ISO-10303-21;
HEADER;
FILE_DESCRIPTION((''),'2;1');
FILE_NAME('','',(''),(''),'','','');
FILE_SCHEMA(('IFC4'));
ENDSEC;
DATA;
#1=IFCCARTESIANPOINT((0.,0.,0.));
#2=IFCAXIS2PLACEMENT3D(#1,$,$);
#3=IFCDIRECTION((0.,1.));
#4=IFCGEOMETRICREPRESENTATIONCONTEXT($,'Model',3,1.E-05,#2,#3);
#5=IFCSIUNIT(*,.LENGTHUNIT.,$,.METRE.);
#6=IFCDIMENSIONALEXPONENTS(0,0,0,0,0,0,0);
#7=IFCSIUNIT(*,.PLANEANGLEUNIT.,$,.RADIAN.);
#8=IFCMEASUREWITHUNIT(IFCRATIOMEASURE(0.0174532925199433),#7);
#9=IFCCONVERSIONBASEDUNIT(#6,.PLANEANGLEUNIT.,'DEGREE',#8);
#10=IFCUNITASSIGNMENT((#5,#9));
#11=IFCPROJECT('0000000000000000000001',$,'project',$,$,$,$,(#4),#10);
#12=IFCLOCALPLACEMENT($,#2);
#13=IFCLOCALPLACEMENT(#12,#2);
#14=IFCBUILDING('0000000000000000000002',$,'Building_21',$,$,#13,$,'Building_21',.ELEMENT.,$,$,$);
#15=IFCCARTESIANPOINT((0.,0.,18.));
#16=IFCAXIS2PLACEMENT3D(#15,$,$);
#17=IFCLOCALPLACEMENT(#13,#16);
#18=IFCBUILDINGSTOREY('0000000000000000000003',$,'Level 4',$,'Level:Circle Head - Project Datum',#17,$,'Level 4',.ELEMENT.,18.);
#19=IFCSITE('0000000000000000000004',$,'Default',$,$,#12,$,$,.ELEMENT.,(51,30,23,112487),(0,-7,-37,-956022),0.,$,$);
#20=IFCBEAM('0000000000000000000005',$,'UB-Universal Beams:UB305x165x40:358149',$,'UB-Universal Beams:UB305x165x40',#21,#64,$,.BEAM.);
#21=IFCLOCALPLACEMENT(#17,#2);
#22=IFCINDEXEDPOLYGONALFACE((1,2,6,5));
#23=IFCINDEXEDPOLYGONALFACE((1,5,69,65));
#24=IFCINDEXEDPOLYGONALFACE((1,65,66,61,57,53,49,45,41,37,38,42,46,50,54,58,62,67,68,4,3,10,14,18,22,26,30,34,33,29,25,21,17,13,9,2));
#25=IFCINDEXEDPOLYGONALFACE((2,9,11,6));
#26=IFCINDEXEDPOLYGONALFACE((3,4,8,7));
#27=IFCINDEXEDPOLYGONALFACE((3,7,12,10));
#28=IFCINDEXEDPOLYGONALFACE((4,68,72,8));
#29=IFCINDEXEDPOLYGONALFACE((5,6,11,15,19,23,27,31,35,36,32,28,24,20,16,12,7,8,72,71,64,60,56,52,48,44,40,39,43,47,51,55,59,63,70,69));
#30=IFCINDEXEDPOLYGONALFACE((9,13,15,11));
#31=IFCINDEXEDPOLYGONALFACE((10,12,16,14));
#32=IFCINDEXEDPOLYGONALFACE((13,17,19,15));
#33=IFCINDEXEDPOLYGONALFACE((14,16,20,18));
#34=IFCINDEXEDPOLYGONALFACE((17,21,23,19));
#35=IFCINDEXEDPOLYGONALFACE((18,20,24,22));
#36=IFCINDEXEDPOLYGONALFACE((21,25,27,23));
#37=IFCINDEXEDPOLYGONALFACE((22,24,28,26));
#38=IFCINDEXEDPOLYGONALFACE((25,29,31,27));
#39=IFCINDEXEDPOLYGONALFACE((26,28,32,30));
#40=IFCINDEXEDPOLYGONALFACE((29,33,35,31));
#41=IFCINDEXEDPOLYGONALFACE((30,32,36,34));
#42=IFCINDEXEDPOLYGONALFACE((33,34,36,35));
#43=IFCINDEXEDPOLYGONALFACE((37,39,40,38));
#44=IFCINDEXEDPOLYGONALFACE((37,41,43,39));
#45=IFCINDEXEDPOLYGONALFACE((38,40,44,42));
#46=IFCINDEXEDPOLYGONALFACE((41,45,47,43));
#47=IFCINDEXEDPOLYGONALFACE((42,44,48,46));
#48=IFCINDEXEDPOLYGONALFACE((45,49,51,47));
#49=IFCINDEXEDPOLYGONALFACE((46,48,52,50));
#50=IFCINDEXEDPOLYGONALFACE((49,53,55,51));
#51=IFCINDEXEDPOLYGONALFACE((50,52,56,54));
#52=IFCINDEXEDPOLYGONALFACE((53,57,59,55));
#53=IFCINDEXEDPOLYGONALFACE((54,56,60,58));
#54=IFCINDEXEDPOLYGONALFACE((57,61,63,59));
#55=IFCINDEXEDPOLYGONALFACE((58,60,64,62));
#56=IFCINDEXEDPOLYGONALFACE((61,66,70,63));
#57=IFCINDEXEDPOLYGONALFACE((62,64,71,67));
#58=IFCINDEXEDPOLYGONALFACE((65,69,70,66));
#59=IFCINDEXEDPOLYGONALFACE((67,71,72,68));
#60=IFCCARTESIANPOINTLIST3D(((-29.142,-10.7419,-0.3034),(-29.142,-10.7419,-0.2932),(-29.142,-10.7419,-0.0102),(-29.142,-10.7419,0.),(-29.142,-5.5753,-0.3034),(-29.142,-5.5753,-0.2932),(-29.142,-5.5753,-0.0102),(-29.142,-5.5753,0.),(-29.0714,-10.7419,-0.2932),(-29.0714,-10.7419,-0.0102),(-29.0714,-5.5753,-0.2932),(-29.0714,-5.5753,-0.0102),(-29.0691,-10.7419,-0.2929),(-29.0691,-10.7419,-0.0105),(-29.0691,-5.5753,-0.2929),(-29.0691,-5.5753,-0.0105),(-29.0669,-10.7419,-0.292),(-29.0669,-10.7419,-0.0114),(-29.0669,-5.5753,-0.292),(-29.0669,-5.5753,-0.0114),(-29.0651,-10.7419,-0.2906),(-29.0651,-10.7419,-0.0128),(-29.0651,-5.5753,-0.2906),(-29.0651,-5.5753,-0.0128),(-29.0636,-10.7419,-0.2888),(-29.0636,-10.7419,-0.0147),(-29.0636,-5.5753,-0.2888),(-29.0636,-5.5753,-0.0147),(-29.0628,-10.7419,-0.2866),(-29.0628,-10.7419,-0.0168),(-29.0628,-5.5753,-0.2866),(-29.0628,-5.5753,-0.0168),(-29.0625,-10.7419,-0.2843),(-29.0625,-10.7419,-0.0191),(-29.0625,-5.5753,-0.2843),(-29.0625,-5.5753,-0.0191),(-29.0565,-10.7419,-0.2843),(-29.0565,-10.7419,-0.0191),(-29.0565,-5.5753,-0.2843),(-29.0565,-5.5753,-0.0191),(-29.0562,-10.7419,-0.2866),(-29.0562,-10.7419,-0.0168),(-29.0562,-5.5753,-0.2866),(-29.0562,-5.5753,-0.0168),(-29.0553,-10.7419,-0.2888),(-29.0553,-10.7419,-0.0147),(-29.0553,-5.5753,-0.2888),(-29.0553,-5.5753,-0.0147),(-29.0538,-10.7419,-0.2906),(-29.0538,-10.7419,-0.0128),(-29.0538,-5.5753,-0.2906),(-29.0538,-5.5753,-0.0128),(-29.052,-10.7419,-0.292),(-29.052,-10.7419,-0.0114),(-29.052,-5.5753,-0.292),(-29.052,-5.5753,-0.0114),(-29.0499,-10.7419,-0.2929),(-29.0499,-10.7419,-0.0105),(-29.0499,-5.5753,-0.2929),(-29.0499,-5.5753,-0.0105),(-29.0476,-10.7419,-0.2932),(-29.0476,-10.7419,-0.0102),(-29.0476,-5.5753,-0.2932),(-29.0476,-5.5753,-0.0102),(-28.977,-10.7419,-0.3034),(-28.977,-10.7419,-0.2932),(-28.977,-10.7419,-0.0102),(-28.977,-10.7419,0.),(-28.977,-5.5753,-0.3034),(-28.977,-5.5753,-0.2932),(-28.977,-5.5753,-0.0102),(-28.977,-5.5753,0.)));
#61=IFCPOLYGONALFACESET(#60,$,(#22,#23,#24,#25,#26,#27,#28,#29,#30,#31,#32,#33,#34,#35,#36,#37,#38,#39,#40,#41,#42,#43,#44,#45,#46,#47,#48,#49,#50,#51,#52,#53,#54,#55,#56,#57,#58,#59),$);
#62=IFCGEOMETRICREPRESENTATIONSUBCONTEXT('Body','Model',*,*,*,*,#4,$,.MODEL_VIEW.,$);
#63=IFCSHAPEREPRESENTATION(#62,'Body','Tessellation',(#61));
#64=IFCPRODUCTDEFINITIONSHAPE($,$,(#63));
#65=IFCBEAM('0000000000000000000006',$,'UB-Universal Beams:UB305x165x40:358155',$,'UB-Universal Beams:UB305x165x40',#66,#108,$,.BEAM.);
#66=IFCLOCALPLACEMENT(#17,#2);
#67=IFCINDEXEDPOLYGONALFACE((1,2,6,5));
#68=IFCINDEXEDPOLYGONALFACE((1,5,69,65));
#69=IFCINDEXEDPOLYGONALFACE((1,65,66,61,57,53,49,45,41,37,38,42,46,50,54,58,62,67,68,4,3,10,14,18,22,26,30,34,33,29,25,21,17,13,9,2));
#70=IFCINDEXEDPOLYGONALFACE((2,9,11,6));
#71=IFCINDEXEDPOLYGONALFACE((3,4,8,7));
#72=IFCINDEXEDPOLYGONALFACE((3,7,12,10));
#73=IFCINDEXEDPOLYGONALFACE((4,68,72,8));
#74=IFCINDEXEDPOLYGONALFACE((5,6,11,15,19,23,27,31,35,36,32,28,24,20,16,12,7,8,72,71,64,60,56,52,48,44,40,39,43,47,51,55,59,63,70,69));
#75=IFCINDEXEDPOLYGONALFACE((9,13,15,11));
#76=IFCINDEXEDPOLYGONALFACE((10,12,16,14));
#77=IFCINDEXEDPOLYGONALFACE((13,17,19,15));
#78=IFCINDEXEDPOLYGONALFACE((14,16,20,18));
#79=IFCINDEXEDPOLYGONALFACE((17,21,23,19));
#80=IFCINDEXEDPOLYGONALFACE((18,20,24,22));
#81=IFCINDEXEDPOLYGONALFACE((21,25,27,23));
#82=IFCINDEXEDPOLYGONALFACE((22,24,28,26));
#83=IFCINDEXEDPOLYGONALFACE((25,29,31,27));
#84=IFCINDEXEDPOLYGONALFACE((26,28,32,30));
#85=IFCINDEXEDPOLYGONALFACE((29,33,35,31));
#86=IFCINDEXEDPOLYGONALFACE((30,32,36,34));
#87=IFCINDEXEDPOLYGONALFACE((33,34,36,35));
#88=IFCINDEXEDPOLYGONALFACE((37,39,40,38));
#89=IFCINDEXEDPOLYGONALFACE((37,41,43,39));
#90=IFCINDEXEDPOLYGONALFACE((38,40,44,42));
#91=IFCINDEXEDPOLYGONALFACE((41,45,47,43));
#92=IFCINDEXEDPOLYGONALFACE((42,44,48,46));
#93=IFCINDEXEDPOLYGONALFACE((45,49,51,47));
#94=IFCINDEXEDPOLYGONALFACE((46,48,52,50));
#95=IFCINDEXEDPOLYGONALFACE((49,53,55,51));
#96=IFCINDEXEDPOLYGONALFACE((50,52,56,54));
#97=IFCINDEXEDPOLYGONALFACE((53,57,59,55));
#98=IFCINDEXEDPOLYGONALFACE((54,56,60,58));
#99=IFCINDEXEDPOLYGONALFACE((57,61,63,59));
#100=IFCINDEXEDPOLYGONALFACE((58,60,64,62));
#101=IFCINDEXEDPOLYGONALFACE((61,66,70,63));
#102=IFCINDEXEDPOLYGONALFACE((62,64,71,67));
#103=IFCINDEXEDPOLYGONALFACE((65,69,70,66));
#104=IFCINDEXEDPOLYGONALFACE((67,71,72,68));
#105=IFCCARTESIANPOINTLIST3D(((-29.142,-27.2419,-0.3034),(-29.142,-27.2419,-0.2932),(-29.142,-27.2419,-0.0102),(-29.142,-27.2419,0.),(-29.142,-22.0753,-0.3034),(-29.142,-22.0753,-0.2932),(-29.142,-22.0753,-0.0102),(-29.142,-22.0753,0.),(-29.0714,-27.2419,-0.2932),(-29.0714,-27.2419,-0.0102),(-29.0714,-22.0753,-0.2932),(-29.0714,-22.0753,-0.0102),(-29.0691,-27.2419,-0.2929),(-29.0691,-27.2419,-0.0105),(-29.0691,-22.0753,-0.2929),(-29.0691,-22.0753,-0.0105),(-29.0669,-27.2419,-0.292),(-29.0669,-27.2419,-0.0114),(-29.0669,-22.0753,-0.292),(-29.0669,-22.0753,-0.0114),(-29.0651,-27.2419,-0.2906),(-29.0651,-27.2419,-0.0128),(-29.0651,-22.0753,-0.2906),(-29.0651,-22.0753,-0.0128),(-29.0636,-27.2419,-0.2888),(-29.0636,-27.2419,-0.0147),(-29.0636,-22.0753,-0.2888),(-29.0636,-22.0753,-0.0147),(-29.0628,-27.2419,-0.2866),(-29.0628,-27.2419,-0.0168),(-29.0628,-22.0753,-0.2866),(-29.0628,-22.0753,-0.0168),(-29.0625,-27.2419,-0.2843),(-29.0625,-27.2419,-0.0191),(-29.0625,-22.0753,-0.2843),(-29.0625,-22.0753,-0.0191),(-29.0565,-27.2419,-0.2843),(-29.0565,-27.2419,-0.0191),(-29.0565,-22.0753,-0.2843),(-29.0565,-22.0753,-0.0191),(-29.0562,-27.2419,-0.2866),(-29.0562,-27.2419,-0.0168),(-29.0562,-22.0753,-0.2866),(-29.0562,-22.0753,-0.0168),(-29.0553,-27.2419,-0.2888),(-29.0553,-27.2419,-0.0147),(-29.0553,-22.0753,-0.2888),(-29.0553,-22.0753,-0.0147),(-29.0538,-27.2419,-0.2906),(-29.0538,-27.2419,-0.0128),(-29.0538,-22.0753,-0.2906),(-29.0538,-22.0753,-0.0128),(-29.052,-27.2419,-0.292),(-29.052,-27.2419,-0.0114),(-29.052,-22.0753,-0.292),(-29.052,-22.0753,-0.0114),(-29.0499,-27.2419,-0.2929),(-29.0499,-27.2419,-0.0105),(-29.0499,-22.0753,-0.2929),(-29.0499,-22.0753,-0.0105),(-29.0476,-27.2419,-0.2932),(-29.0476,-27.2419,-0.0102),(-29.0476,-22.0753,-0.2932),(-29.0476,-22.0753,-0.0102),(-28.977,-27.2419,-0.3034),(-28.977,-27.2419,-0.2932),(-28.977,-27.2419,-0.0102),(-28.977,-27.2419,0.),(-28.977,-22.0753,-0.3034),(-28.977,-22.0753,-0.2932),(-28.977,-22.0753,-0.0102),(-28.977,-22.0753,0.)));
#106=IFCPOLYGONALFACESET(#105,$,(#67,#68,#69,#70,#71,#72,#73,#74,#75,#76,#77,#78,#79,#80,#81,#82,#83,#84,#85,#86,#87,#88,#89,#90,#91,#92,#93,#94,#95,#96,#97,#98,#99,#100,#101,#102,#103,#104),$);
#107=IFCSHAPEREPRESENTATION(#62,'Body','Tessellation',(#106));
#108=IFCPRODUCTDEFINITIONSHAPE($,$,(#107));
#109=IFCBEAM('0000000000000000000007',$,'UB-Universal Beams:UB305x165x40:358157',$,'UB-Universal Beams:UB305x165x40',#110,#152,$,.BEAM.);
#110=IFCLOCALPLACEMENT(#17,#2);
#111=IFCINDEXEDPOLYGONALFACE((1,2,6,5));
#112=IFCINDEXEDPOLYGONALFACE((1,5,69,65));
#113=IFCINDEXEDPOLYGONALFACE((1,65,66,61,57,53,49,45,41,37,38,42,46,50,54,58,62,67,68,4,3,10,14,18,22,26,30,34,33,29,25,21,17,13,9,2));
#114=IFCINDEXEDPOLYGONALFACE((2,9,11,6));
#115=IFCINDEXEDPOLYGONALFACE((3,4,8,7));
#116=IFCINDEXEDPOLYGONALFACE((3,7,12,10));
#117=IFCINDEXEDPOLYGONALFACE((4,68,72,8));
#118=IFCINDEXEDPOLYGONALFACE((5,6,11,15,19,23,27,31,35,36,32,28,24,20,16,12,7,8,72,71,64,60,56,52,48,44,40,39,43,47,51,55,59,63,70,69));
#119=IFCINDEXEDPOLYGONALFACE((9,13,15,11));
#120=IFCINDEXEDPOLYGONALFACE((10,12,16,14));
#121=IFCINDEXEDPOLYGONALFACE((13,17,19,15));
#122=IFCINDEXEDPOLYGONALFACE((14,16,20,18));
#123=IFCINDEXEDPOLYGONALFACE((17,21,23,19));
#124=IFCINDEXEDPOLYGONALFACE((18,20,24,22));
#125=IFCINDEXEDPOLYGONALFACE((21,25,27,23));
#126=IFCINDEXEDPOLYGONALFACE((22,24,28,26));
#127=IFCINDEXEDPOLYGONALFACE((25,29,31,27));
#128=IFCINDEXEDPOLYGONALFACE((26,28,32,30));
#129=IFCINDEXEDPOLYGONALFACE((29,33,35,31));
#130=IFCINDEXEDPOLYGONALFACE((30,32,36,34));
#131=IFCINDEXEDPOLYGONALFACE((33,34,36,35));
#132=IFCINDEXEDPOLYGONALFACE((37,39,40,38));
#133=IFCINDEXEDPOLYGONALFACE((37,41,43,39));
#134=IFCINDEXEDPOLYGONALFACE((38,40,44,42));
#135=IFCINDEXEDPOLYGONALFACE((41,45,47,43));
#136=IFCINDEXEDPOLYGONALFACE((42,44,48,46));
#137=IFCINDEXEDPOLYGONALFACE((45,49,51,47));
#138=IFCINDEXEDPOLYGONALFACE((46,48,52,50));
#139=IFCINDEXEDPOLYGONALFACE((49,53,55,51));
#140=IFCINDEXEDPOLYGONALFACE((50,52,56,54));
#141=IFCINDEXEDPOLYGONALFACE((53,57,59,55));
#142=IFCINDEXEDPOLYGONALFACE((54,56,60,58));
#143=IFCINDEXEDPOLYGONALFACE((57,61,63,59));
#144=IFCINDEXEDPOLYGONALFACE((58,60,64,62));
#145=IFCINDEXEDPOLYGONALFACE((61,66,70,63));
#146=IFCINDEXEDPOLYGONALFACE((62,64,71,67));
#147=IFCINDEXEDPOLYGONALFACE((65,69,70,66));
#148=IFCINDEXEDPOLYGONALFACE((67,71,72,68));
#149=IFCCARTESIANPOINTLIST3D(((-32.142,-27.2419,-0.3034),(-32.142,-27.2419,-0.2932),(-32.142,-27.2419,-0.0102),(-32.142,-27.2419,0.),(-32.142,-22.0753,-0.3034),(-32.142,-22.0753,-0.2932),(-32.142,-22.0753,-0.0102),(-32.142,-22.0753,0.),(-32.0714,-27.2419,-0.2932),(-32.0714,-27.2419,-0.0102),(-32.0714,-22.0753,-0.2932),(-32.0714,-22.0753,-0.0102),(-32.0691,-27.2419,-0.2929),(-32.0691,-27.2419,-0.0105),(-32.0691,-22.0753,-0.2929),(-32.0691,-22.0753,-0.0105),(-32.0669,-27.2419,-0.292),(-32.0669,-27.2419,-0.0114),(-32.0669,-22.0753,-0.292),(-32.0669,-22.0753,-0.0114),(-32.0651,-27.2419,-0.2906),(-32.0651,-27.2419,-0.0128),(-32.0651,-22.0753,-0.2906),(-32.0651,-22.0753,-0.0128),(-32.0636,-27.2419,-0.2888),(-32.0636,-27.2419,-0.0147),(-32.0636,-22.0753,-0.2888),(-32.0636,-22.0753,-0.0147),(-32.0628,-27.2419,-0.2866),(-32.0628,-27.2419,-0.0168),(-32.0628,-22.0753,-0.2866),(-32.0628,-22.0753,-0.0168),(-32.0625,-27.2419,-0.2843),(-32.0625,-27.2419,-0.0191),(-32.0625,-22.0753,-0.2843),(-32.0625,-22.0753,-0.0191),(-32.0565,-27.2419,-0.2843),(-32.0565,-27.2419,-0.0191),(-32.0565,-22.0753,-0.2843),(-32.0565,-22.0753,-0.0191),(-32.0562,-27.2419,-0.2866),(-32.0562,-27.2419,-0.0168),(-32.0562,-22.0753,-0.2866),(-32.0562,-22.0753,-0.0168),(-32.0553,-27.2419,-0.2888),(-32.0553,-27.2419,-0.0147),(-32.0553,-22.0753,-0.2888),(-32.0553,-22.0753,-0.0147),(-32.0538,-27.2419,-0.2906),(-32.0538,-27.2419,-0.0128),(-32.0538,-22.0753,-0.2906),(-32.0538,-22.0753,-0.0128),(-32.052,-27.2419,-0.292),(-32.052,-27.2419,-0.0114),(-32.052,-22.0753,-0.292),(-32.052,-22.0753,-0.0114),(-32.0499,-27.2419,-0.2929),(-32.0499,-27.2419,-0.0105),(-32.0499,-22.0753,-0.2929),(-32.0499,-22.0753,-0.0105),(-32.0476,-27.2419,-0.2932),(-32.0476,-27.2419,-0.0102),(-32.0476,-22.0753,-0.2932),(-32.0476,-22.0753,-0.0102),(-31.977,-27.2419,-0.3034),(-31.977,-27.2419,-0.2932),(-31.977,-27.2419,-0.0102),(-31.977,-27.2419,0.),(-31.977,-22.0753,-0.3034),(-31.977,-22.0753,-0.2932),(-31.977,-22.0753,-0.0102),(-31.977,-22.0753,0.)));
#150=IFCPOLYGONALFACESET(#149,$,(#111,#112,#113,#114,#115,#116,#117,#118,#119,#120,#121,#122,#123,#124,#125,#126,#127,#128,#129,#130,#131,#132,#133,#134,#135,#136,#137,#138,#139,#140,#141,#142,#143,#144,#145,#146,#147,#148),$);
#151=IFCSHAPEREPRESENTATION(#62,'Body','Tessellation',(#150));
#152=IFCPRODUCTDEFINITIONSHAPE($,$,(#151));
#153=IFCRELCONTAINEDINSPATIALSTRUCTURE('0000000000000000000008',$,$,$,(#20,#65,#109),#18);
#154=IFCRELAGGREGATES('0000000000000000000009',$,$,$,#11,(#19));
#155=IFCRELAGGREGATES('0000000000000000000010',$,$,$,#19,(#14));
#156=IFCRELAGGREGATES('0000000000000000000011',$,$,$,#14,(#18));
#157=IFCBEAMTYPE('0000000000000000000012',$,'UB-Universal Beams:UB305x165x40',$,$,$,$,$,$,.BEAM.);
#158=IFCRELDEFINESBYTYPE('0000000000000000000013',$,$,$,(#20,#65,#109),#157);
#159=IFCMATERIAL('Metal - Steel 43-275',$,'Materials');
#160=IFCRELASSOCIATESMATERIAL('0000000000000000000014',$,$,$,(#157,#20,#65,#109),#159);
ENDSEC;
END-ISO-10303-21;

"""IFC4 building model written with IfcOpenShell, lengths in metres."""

from ifc_helpers import new_model, entity, si_unit, converted_unit, direction, frame, frame_2d, origin, place, context, subcontext, project, spatial, polyline, circle_curve, parameter, trimmed, segment, composite_curve, i_section, outline, extrude, source, transform, mapped, material, material_profile, profile_set, profile_usage, type_object, type_shapes, element, save


model = new_model("IFC4")

# Units and contexts
model_context = context("Model", 3, precision=1e-05, world=origin(), true_north=direction((0.0, 1.0)))
body_context = subcontext(model_context, "Body", "Model", "MODEL_VIEW")
ifc_project = project(units=[si_unit("LENGTHUNIT", "METRE"), converted_unit("PLANEANGLEUNIT", "DEGREE", entity("IfcRatioMeasure", 0.0174532925199433), si_unit("PLANEANGLEUNIT", "RADIAN"), dimensions=[0, 0, 0, 0, 0, 0, 0])], contexts=[model_context])

# Site, building, storey
site_placement = place(None, origin())
site = spatial("IfcSite", under=ifc_project, at=site_placement, Name="Default", CompositionType="ELEMENT", RefLatitude=(51, 30, 23, 112487), RefLongitude=(0, -7, -37, -956022), RefElevation=0.0)
building_placement = place(site_placement, origin())
building = spatial("IfcBuilding", under=site, at=building_placement, Name="Building_21", LongName="Building_21", CompositionType="ELEMENT")
storey_placement = place(building_placement, frame((0.0, 0.0, 18.0)))
storey = spatial("IfcBuildingStorey", under=building, at=storey_placement, Name="Level 4", ObjectType="Level:Circle Head - Project Datum", LongName="Level 4", CompositionType="ELEMENT", Elevation=18.0)

# Beams
ifc_material_1 = material(Name="Metal - Steel 43-275", Category="Materials")
ifc_material_profile_1 = material_profile(ifc_material_1, outline(composite_curve([segment(polyline([(0.0119, -0.1415, 0.0), (0.0825, -0.1415, 0.0)]), True, "CONTINUOUS"), segment(polyline([(0.0825, -0.1415, 0.0), (0.0825, -0.1517, 0.0)]), True, "CONTINUOUS"), segment(polyline([(0.0825, -0.1517, 0.0), (-0.0825, -0.1517, 0.0)]), True, "CONTINUOUS"), segment(polyline([(-0.0825, -0.1517, 0.0), (-0.0825, -0.1415, 0.0)]), True, "CONTINUOUS"), segment(polyline([(-0.0825, -0.1415, 0.0), (-0.0119, -0.1415, 0.0)]), True, "CONTINUOUS"), segment(trimmed(circle_curve(frame((-0.0119, -0.1326, 0.0), z_axis=(0.0, 0.0, 1.0), x_axis=(-1.0, 0.0, 0.0)), 0.0089), [parameter(90.0)], [parameter(180.0)], True, "PARAMETER"), True, "CONTINUOUS"), segment(polyline([(-0.003, -0.1326, 0.0), (-0.003, 0.1326, 0.0)]), True, "CONTINUOUS"), segment(trimmed(circle_curve(frame((-0.0119, 0.1326, 0.0), z_axis=(0.0, 0.0, 1.0), x_axis=(-1.0, 0.0, 0.0)), 0.0089), [parameter(180.0)], [parameter(270.0)], True, "PARAMETER"), True, "CONTINUOUS"), segment(polyline([(-0.0119, 0.1415, 0.0), (-0.0825, 0.1415, 0.0)]), True, "CONTINUOUS"), segment(polyline([(-0.0825, 0.1415, 0.0), (-0.0825, 0.1517, 0.0)]), True, "CONTINUOUS"), segment(polyline([(-0.0825, 0.1517, 0.0), (0.0825, 0.1517, 0.0)]), True, "CONTINUOUS"), segment(polyline([(0.0825, 0.1517, 0.0), (0.0825, 0.1415, 0.0)]), True, "CONTINUOUS"), segment(polyline([(0.0825, 0.1415, 0.0), (0.0119, 0.1415, 0.0)]), True, "CONTINUOUS"), segment(trimmed(circle_curve(frame((0.0119, 0.1326, 0.0), z_axis=(0.0, 0.0, 1.0), x_axis=(-1.0, 0.0, 0.0)), 0.0089), [parameter(270.0)], [parameter(0.0)], True, "PARAMETER"), True, "CONTINUOUS"), segment(polyline([(0.003, 0.1326, 0.0), (0.003, -0.1326, 0.0)]), True, "CONTINUOUS"), segment(trimmed(circle_curve(frame((0.0119, -0.1326, 0.0), z_axis=(0.0, 0.0, 1.0), x_axis=(-1.0, 0.0, 0.0)), 0.0089), [parameter(0.0)], [parameter(90.0)], True, "PARAMETER"), True, "CONTINUOUS")], self_intersect=False), kind="CURVE"), Name="UB305x165x40")
ifc_material_profile_2 = material_profile(ifc_material_1, outline(composite_curve([segment(polyline([(-1.3346, 0.0825, -0.1415), (-1.3346, 0.0825, -0.1517)]), True, "CONTINUOUS"), segment(polyline([(-1.3346, 0.0825, -0.1517), (-1.3346, -0.0825, -0.1517)]), True, "CONTINUOUS"), segment(polyline([(-1.3346, -0.0825, -0.1517), (-1.3346, -0.0825, -0.1415)]), True, "CONTINUOUS"), segment(polyline([(-1.3346, -0.0825, -0.1415), (-1.3346, -0.003, -0.1415)]), True, "CONTINUOUS"), segment(polyline([(-1.3346, -0.003, -0.1415), (-1.3346, -0.003, 0.1415)]), True, "CONTINUOUS"), segment(polyline([(-1.3346, -0.003, 0.1415), (-1.3346, -0.0825, 0.1415)]), True, "CONTINUOUS"), segment(polyline([(-1.3346, -0.0825, 0.1415), (-1.3346, -0.0825, 0.1517)]), True, "CONTINUOUS"), segment(polyline([(-1.3346, -0.0825, 0.1517), (-1.3346, 0.0825, 0.1517)]), True, "CONTINUOUS"), segment(polyline([(-1.3346, 0.0825, 0.1517), (-1.3346, 0.0825, 0.1415)]), True, "CONTINUOUS"), segment(polyline([(-1.3346, 0.0825, 0.1415), (-1.3346, 0.003, 0.1415)]), True, "CONTINUOUS"), segment(polyline([(-1.3346, 0.003, 0.1415), (-1.3346, 0.003, -0.1415)]), True, "CONTINUOUS"), segment(polyline([(-1.3346, 0.003, -0.1415), (-1.3346, 0.0825, -0.1415)]), True, "CONTINUOUS")], self_intersect=False), kind="CURVE"), Name="UB305x165x40")
ifc_profile_set = profile_set([ifc_material_profile_1, ifc_material_profile_2], Name="UB305x165x40")
ifc_profile_usage_1 = profile_usage(ifc_profile_set, cardinal=8)
beam_type_1 = type_object("IfcBeamType", Name="UB-Universal Beams:UB305x165x40", PredefinedType="BEAM", material=ifc_profile_set)
shared_shape_1 = source(origin(), body_context, "Body", "SweptSolid", [
    extrude(i_section(OverallWidth=0.165, OverallDepth=0.3034, WebThickness=0.006, FlangeThickness=0.0102, FilletRadius=0.0089, at=frame_2d((0.0, 0.0), x_axis=(0.0, 1.0))), frame((-2.5833, 0.0, 0.0), z_axis=(1.0, 0.0, 0.0), x_axis=(0.0, 0.0, -1.0)), (0.0, 0.0, 1.0), 5.1666),
])
type_shapes(beam_type_1, [shared_shape_1])
beam_1_placement = place(storey_placement, frame((-29.0595, -8.1586, -0.1517), z_axis=(0.0, 0.0, 1.0), x_axis=(0.0, 1.0, 0.0)))
element("IfcBeam", 1, at=beam_1_placement, inside=storey, type_object=beam_type_1, material=ifc_profile_usage_1, Name="UB-Universal Beams:UB305x165x40:358149", ObjectType="UB-Universal Beams:UB305x165x40", PredefinedType="BEAM", context=body_context, shape_type="MappedRepresentation", body=[
    mapped(shared_shape_1, transform((0.0, 0.0, 0.0), scale=1.0)),
])
ifc_profile_usage_2 = profile_usage(ifc_profile_set, cardinal=8)
beam_2_placement = place(storey_placement, frame((-29.0595, -24.6586, -0.1517), z_axis=(0.0, 0.0, 1.0), x_axis=(0.0, 1.0, 0.0)))
element("IfcBeam", 2, at=beam_2_placement, inside=storey, type_object=beam_type_1, material=ifc_profile_usage_2, Name="UB-Universal Beams:UB305x165x40:358155", ObjectType="UB-Universal Beams:UB305x165x40", PredefinedType="BEAM", context=body_context, shape_type="MappedRepresentation", body=[
    mapped(shared_shape_1, transform((0.0, 0.0, 0.0), scale=1.0)),
])
ifc_profile_usage_3 = profile_usage(ifc_profile_set, cardinal=8)
beam_3_placement = place(storey_placement, frame((-32.0595, -24.6586, -0.1517), z_axis=(0.0, 0.0, 1.0), x_axis=(0.0, 1.0, 0.0)))
element("IfcBeam", 3, at=beam_3_placement, inside=storey, type_object=beam_type_1, material=ifc_profile_usage_3, Name="UB-Universal Beams:UB305x165x40:358157", ObjectType="UB-Universal Beams:UB305x165x40", PredefinedType="BEAM", context=body_context, shape_type="MappedRepresentation", body=[
    mapped(shared_shape_1, transform((0.0, 0.0, 0.0), scale=1.0)),
])

save(model, "model.ifc")
